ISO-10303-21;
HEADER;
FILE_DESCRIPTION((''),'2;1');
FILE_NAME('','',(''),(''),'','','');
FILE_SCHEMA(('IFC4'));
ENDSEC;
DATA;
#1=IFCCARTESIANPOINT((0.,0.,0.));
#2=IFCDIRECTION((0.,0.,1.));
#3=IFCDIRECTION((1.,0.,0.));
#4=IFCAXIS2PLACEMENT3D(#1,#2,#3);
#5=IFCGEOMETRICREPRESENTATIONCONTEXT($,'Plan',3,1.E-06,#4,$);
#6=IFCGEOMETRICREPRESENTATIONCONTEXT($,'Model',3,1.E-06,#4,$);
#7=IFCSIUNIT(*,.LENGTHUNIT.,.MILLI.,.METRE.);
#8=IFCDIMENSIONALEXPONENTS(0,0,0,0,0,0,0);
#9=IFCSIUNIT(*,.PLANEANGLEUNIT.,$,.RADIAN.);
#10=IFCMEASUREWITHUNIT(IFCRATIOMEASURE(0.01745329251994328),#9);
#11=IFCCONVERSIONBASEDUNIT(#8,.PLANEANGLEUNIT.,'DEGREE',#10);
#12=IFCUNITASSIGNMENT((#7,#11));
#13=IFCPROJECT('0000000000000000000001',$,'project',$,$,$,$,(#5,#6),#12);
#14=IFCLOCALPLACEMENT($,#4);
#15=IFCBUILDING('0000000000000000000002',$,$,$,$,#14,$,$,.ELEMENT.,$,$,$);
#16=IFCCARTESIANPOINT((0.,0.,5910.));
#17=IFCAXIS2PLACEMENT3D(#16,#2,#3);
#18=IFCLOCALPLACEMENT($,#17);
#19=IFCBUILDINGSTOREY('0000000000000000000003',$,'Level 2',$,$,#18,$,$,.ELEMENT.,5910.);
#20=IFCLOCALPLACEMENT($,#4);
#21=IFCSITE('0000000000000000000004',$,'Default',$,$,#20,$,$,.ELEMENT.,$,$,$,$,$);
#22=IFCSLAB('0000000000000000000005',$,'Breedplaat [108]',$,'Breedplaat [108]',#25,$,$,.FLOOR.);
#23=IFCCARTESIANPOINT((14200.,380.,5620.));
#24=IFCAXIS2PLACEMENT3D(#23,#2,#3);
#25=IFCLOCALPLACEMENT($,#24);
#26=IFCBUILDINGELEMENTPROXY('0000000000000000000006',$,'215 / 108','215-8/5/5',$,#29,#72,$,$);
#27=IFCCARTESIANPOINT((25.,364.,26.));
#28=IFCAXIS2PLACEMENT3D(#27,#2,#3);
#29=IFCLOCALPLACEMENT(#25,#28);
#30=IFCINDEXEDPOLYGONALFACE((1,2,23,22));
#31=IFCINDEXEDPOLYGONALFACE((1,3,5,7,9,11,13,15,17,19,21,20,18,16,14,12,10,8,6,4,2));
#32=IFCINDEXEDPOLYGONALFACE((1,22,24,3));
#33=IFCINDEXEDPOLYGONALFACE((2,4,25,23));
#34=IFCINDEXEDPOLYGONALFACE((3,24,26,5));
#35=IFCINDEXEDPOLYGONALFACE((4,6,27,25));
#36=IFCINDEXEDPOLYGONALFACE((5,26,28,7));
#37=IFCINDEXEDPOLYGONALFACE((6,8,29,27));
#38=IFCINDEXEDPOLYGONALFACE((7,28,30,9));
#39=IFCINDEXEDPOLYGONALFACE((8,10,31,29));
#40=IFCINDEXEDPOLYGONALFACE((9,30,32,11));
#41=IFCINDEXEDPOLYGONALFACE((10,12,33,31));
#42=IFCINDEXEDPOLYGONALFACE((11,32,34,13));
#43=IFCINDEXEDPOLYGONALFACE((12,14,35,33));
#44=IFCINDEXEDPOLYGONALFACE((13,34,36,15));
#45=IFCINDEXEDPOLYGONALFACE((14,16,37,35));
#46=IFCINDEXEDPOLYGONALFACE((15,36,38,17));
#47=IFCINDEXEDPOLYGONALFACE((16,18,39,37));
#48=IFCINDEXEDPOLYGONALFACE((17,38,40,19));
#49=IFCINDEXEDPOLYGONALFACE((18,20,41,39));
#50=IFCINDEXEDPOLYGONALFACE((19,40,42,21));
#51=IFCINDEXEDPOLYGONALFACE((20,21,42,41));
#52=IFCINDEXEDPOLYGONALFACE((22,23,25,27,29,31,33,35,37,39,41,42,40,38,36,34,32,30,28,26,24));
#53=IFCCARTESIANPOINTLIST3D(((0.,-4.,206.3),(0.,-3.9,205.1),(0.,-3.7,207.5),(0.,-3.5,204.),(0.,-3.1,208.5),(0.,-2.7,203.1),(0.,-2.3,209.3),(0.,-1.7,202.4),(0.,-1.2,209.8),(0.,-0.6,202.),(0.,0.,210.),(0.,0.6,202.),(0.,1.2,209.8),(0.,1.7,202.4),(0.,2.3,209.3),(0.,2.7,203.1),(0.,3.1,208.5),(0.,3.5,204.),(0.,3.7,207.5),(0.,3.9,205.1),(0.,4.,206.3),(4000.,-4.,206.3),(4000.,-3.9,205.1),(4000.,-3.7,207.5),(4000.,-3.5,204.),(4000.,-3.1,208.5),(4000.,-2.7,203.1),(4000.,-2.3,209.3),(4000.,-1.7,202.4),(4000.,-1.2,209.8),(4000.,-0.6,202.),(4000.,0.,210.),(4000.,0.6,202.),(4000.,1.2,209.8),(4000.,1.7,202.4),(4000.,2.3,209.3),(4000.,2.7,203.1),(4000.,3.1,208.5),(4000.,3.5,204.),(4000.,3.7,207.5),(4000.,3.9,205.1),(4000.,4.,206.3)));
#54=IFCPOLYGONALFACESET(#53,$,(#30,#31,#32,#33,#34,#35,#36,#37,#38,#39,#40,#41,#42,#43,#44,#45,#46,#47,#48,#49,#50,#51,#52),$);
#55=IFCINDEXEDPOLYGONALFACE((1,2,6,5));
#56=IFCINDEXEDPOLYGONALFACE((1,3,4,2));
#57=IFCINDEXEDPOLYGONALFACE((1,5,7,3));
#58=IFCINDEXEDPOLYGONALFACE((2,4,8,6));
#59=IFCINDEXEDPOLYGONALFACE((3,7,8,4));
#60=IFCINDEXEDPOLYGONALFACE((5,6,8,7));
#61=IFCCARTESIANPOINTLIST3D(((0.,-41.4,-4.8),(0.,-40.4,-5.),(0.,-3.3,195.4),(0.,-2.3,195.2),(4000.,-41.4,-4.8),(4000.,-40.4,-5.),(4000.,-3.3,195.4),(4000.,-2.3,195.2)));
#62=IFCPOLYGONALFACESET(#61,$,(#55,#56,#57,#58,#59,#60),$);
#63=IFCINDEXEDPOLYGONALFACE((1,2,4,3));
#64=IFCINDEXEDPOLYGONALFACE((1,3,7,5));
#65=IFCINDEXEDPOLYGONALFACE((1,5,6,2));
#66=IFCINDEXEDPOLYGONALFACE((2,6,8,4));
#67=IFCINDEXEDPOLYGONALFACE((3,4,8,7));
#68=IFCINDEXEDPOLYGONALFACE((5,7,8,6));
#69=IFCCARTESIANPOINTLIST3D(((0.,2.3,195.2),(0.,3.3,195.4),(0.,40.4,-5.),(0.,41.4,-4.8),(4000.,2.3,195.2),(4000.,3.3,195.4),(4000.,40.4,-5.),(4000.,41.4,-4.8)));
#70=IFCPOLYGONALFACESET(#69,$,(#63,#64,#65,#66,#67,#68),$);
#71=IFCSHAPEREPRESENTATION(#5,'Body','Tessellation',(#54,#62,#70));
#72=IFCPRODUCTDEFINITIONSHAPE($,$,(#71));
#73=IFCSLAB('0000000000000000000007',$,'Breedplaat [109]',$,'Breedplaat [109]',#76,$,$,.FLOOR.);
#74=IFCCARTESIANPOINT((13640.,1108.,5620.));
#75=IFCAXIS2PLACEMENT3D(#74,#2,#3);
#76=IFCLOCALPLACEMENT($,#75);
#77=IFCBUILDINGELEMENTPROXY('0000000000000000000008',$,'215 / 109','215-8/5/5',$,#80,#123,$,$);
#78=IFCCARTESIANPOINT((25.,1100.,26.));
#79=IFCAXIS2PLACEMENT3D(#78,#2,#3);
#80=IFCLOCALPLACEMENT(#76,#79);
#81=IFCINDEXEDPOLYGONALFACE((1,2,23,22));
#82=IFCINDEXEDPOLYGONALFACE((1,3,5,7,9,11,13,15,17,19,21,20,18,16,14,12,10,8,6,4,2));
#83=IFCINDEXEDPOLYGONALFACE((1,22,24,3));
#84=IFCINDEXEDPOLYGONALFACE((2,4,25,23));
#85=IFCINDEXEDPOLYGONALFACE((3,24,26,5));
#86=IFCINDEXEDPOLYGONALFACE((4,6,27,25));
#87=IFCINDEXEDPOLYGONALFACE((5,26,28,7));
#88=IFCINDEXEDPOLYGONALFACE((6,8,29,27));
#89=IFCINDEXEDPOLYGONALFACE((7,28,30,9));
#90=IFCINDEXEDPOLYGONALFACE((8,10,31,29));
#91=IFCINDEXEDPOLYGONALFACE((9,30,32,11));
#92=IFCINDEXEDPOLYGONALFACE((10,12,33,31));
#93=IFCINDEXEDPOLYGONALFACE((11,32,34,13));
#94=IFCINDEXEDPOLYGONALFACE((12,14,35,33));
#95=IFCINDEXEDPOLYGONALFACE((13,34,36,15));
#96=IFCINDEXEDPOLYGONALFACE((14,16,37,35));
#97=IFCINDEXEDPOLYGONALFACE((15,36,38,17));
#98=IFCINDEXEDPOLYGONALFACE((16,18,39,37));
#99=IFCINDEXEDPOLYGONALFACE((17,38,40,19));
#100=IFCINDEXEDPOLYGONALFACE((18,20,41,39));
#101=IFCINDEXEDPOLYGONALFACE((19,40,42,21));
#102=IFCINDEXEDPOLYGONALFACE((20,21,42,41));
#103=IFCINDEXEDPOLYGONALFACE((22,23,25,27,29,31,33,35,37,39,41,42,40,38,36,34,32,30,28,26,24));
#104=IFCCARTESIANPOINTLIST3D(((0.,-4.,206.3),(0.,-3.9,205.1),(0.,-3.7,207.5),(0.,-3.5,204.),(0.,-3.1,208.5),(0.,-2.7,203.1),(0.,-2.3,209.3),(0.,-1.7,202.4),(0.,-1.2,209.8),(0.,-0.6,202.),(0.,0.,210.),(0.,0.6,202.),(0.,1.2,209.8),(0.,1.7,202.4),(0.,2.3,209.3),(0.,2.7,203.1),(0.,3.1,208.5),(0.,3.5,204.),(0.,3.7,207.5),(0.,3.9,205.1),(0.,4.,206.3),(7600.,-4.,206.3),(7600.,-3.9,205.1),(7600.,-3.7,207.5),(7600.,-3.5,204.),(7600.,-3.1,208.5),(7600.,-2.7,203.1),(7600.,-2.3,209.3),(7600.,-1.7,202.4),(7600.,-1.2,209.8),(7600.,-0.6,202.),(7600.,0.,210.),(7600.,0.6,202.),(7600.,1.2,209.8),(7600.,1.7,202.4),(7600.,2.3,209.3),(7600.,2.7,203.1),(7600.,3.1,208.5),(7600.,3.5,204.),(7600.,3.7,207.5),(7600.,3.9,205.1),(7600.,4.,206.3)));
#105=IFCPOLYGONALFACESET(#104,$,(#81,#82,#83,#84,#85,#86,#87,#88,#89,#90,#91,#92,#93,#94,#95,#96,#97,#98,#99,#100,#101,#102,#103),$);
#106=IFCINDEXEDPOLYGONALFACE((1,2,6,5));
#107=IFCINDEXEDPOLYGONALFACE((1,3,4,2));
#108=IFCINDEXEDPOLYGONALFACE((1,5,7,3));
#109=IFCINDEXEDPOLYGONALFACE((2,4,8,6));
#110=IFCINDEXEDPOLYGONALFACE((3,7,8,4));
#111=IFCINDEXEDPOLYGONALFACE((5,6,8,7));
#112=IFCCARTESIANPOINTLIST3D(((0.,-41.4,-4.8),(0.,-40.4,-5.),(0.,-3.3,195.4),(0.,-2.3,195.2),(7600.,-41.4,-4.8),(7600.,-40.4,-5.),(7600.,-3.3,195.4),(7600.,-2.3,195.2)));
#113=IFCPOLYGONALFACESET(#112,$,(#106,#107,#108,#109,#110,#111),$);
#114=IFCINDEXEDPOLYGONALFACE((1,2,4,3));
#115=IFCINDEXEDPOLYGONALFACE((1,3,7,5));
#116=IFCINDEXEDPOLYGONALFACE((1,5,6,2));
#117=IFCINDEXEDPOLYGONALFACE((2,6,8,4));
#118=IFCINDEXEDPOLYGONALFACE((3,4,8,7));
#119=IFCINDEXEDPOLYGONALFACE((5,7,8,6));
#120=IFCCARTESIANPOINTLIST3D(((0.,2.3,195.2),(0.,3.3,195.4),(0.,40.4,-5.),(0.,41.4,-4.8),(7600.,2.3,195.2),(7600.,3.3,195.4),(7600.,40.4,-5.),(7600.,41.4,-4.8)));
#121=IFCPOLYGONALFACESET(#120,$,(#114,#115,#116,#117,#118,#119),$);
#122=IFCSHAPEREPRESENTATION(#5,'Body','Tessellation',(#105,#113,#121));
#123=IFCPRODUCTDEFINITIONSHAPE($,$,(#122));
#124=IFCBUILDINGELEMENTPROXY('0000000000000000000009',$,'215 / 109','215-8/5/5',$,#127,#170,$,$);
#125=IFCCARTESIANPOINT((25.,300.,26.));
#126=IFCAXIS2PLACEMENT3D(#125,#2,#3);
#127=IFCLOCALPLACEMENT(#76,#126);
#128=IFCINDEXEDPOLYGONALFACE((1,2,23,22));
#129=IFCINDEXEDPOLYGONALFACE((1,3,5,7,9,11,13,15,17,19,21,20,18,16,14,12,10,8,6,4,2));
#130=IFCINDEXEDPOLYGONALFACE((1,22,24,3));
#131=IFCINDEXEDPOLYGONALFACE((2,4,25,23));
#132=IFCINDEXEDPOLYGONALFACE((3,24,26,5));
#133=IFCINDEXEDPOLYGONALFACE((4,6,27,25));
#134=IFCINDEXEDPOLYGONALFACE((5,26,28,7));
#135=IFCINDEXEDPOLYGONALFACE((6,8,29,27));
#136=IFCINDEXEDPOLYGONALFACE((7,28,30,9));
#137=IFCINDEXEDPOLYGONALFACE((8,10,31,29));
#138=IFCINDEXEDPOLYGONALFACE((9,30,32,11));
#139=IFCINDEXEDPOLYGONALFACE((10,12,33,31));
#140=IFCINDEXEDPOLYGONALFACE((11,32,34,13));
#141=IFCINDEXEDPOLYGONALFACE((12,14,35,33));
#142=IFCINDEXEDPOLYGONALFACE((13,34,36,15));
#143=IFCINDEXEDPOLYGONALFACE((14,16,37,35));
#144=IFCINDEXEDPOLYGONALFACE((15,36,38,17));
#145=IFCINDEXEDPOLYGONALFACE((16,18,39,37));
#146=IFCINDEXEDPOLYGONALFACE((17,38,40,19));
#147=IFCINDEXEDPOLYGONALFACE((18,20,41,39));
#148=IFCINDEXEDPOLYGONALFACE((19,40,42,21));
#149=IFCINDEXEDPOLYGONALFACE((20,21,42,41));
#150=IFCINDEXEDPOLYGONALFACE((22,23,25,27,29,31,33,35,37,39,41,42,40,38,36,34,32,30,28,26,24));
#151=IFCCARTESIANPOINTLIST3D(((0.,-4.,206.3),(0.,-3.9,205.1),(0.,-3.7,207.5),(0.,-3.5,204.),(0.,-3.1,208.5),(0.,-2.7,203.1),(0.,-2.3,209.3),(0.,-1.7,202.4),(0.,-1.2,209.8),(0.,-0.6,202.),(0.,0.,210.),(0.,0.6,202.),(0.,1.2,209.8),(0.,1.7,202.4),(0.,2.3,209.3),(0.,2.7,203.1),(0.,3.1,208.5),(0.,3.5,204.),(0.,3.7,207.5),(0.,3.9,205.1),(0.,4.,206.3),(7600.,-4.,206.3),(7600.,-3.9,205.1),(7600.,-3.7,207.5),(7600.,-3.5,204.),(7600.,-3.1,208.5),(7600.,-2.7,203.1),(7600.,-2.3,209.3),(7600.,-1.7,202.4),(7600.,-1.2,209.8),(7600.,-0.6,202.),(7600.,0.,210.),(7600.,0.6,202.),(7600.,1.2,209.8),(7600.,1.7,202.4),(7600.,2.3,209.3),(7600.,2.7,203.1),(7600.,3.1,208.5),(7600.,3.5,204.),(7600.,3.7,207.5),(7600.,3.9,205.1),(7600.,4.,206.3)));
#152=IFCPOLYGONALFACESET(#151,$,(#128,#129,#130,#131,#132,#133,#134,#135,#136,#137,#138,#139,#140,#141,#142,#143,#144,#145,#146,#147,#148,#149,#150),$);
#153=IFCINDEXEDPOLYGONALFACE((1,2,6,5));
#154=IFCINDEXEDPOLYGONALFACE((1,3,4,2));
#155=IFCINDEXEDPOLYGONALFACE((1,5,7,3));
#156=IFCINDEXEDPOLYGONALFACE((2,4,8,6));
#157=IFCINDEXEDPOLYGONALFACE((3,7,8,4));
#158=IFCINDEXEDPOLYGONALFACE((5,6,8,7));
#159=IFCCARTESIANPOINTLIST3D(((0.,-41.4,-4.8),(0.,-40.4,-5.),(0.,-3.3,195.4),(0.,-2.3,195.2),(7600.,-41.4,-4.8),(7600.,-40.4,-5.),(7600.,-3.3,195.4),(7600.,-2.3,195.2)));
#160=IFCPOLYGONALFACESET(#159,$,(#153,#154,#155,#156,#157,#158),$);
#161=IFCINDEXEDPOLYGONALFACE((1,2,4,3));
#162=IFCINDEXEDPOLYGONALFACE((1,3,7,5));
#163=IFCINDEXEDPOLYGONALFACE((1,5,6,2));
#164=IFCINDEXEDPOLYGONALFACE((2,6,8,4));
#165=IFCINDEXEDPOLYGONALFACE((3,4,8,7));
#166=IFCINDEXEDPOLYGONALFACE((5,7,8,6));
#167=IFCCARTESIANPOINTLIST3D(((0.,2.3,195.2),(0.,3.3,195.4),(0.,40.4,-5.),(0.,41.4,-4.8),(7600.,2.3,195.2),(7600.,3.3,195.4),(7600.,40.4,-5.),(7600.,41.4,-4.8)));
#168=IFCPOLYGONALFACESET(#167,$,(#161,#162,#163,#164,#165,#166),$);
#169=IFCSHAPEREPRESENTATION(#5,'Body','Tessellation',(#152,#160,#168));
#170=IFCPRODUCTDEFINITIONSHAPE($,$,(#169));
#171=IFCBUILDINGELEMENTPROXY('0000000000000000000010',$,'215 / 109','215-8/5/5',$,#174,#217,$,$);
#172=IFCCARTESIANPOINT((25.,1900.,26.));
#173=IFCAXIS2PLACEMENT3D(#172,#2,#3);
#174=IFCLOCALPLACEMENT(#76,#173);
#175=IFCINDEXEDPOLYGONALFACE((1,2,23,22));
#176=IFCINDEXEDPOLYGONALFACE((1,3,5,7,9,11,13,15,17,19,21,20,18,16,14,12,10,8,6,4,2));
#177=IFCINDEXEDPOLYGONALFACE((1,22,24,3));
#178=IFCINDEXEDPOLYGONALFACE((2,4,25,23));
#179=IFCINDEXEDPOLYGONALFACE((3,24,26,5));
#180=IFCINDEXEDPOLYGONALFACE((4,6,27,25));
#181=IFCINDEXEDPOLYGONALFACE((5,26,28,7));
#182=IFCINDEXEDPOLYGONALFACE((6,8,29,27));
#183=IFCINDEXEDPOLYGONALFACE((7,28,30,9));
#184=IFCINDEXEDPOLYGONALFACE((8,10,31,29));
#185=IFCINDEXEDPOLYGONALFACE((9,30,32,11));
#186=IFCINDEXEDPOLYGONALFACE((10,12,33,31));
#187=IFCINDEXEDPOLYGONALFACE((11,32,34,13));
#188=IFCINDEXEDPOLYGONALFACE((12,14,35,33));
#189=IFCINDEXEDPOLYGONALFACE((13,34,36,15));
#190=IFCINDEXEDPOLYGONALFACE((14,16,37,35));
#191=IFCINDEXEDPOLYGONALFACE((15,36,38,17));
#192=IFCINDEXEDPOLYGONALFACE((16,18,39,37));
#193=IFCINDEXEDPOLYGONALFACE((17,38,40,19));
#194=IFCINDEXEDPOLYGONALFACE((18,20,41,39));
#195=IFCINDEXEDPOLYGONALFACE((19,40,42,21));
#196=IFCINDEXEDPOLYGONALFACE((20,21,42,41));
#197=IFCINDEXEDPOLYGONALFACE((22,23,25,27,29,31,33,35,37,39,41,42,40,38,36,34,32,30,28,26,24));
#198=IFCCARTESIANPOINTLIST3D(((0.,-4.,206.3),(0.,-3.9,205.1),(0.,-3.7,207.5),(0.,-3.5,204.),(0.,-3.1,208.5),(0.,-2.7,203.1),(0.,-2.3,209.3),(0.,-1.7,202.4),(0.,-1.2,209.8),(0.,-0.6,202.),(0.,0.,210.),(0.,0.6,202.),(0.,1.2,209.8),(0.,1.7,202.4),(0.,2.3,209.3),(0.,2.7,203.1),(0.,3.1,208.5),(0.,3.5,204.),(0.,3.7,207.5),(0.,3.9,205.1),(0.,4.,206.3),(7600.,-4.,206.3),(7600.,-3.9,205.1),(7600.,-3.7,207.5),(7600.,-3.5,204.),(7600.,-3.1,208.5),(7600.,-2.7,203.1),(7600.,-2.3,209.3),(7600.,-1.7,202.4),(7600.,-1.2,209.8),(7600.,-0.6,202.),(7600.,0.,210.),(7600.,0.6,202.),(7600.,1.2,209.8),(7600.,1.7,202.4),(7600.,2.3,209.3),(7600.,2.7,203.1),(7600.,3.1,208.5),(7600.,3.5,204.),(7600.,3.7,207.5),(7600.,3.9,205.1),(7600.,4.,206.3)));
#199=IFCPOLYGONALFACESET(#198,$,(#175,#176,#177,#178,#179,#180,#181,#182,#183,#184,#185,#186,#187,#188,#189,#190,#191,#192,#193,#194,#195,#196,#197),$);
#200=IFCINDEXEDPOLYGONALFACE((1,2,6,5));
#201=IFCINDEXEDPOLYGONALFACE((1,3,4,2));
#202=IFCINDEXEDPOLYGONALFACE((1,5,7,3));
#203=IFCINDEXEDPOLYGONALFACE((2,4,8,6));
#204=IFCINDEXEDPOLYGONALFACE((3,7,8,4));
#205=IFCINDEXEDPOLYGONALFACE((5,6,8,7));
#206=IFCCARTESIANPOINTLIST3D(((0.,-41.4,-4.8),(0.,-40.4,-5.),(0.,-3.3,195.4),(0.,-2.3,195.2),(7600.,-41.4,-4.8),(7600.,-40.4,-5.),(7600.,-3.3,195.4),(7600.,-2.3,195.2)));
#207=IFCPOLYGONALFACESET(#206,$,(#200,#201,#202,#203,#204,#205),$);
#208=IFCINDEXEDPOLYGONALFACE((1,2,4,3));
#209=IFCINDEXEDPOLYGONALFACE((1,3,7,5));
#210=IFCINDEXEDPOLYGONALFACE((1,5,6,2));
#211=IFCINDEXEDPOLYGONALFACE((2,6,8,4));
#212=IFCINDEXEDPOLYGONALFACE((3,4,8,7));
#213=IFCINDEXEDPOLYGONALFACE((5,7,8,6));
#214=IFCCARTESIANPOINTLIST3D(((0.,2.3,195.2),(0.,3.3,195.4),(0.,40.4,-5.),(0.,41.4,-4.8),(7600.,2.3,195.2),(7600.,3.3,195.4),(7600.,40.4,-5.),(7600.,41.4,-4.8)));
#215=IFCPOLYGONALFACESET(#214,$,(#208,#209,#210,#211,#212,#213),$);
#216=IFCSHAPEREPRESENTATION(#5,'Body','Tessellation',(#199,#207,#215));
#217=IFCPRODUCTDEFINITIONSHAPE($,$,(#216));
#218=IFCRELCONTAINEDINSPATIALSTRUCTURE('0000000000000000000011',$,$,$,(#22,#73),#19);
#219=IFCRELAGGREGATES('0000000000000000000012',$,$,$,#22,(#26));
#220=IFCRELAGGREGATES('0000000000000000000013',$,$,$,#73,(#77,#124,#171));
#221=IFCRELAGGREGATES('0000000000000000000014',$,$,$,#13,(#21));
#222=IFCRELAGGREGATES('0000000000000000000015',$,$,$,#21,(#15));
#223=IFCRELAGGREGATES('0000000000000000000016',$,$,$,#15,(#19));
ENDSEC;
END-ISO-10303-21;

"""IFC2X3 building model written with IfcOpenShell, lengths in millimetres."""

from ifc_helpers import new_model, entity, si_unit, converted_unit, frame, origin_with_axes, origin_2d_with_axis, place, context, project, spatial, rectangle, circle, extrude, element, aggregate, save


model = new_model("IFC2X3")

# Units and contexts
plan_context = context("Plan", 3, precision=1e-06, world=origin_with_axes())
model_context = context("Model", 3, precision=1e-06, world=origin_with_axes())
ifc_project = project(units=[si_unit("LENGTHUNIT", "METRE", prefix="MILLI"), converted_unit("PLANEANGLEUNIT", "DEGREE", entity("IfcRatioMeasure", 0.01745329251994328), si_unit("PLANEANGLEUNIT", "RADIAN"), dimensions=[0, 0, 0, 0, 0, 0, 0])], contexts=[plan_context, model_context])

# Site, building, storey
site_placement = place(None, origin_with_axes())
site = spatial("IfcSite", under=ifc_project, at=site_placement, Name="Default", CompositionType="ELEMENT")
building_placement = place(None, origin_with_axes())
building = spatial("IfcBuilding", under=site, at=building_placement, CompositionType="ELEMENT")
storey_placement = place(None, frame((0.0, 0.0, 5910.0), z_axis=(0.0, 0.0, 1.0), x_axis=(1.0, 0.0, 0.0)))
storey = spatial("IfcBuildingStorey", under=building, at=storey_placement, Name="Level 2", CompositionType="ELEMENT", Elevation=5910.0)

# Slab, building element proxy
slab_1_placement = place(None, frame((14200.0, 380.0, 5620.0), z_axis=(0.0, 0.0, 1.0), x_axis=(1.0, 0.0, 0.0)))
slab_1 = element("IfcSlab", 1, at=slab_1_placement, inside=storey, Name="Breedplaat [108]", ObjectType="Breedplaat [108]", PredefinedType="FLOOR")
proxy_1_placement = place(slab_1_placement, frame((25.0, 364.0, 26.0), z_axis=(0.0, 0.0, 1.0), x_axis=(1.0, 0.0, 0.0)))
proxy_1 = element("IfcBuildingElementProxy", 2, at=proxy_1_placement, Name="215 / 108", Description="215-8/5/5", context=plan_context, shape_type="SweptSolid", body=[
    extrude(circle(Radius=4.0, at=origin_2d_with_axis()), frame((0.0, 0.0, 206.0), z_axis=(1.0, 0.0, 0.0), x_axis=(0.0, 0.0, 1.0)), (0.0, 0.0, 1.0), 4000.0),
    extrude(rectangle(XDim=203.8, YDim=1.0, at=origin_2d_with_axis()), frame((0.0, -21.9, 95.2), z_axis=(1.0, 0.0, 0.0), x_axis=(0.0, 0.187112, 0.982339)), (0.0, 0.0, 1.0), 4000.0),
    extrude(rectangle(XDim=203.8, YDim=1.0, at=origin_2d_with_axis()), frame((0.0, 21.9, 95.2), z_axis=(1.0, 0.0, 0.0), x_axis=(0.0, -0.187112, 0.982339)), (0.0, 0.0, 1.0), 4000.0),
])
aggregate(slab_1, [proxy_1])

# Slab, building element proxies
slab_2_placement = place(None, frame((13640.0, 1108.0, 5620.0), z_axis=(0.0, 0.0, 1.0), x_axis=(1.0, 0.0, 0.0)))
slab_2 = element("IfcSlab", 3, at=slab_2_placement, inside=storey, Name="Breedplaat [109]", ObjectType="Breedplaat [109]", PredefinedType="FLOOR")
proxy_2_placement = place(slab_2_placement, frame((25.0, 1100.0, 26.0), z_axis=(0.0, 0.0, 1.0), x_axis=(1.0, 0.0, 0.0)))
proxy_2 = element("IfcBuildingElementProxy", 4, at=proxy_2_placement, Name="215 / 109", Description="215-8/5/5", context=plan_context, shape_type="SweptSolid", body=[
    extrude(circle(Radius=4.0, at=origin_2d_with_axis()), frame((0.0, 0.0, 206.0), z_axis=(1.0, 0.0, 0.0), x_axis=(0.0, 0.0, 1.0)), (0.0, 0.0, 1.0), 7600.0),
    extrude(rectangle(XDim=203.8, YDim=1.0, at=origin_2d_with_axis()), frame((0.0, -21.9, 95.2), z_axis=(1.0, 0.0, 0.0), x_axis=(0.0, 0.187112, 0.982339)), (0.0, 0.0, 1.0), 7600.0),
    extrude(rectangle(XDim=203.8, YDim=1.0, at=origin_2d_with_axis()), frame((0.0, 21.9, 95.2), z_axis=(1.0, 0.0, 0.0), x_axis=(0.0, -0.187112, 0.982339)), (0.0, 0.0, 1.0), 7600.0),
])
proxy_3_placement = place(slab_2_placement, frame((25.0, 300.0, 26.0), z_axis=(0.0, 0.0, 1.0), x_axis=(1.0, 0.0, 0.0)))
proxy_3 = element("IfcBuildingElementProxy", 5, at=proxy_3_placement, Name="215 / 109", Description="215-8/5/5", context=plan_context, shape_type="SweptSolid", body=[
    extrude(circle(Radius=4.0, at=origin_2d_with_axis()), frame((0.0, 0.0, 206.0), z_axis=(1.0, 0.0, 0.0), x_axis=(0.0, 0.0, 1.0)), (0.0, 0.0, 1.0), 7600.0),
    extrude(rectangle(XDim=203.8, YDim=1.0, at=origin_2d_with_axis()), frame((0.0, -21.9, 95.2), z_axis=(1.0, 0.0, 0.0), x_axis=(0.0, 0.187112, 0.982339)), (0.0, 0.0, 1.0), 7600.0),
    extrude(rectangle(XDim=203.8, YDim=1.0, at=origin_2d_with_axis()), frame((0.0, 21.9, 95.2), z_axis=(1.0, 0.0, 0.0), x_axis=(0.0, -0.187112, 0.982339)), (0.0, 0.0, 1.0), 7600.0),
])
proxy_4_placement = place(slab_2_placement, frame((25.0, 1900.0, 26.0), z_axis=(0.0, 0.0, 1.0), x_axis=(1.0, 0.0, 0.0)))
proxy_4 = element("IfcBuildingElementProxy", 6, at=proxy_4_placement, Name="215 / 109", Description="215-8/5/5", context=plan_context, shape_type="SweptSolid", body=[
    extrude(circle(Radius=4.0, at=origin_2d_with_axis()), frame((0.0, 0.0, 206.0), z_axis=(1.0, 0.0, 0.0), x_axis=(0.0, 0.0, 1.0)), (0.0, 0.0, 1.0), 7600.0),
    extrude(rectangle(XDim=203.8, YDim=1.0, at=origin_2d_with_axis()), frame((0.0, -21.9, 95.2), z_axis=(1.0, 0.0, 0.0), x_axis=(0.0, 0.187112, 0.982339)), (0.0, 0.0, 1.0), 7600.0),
    extrude(rectangle(XDim=203.8, YDim=1.0, at=origin_2d_with_axis()), frame((0.0, 21.9, 95.2), z_axis=(1.0, 0.0, 0.0), x_axis=(0.0, -0.187112, 0.982339)), (0.0, 0.0, 1.0), 7600.0),
])
aggregate(slab_2, [proxy_2, proxy_3, proxy_4])

save(model, "model.ifc")
